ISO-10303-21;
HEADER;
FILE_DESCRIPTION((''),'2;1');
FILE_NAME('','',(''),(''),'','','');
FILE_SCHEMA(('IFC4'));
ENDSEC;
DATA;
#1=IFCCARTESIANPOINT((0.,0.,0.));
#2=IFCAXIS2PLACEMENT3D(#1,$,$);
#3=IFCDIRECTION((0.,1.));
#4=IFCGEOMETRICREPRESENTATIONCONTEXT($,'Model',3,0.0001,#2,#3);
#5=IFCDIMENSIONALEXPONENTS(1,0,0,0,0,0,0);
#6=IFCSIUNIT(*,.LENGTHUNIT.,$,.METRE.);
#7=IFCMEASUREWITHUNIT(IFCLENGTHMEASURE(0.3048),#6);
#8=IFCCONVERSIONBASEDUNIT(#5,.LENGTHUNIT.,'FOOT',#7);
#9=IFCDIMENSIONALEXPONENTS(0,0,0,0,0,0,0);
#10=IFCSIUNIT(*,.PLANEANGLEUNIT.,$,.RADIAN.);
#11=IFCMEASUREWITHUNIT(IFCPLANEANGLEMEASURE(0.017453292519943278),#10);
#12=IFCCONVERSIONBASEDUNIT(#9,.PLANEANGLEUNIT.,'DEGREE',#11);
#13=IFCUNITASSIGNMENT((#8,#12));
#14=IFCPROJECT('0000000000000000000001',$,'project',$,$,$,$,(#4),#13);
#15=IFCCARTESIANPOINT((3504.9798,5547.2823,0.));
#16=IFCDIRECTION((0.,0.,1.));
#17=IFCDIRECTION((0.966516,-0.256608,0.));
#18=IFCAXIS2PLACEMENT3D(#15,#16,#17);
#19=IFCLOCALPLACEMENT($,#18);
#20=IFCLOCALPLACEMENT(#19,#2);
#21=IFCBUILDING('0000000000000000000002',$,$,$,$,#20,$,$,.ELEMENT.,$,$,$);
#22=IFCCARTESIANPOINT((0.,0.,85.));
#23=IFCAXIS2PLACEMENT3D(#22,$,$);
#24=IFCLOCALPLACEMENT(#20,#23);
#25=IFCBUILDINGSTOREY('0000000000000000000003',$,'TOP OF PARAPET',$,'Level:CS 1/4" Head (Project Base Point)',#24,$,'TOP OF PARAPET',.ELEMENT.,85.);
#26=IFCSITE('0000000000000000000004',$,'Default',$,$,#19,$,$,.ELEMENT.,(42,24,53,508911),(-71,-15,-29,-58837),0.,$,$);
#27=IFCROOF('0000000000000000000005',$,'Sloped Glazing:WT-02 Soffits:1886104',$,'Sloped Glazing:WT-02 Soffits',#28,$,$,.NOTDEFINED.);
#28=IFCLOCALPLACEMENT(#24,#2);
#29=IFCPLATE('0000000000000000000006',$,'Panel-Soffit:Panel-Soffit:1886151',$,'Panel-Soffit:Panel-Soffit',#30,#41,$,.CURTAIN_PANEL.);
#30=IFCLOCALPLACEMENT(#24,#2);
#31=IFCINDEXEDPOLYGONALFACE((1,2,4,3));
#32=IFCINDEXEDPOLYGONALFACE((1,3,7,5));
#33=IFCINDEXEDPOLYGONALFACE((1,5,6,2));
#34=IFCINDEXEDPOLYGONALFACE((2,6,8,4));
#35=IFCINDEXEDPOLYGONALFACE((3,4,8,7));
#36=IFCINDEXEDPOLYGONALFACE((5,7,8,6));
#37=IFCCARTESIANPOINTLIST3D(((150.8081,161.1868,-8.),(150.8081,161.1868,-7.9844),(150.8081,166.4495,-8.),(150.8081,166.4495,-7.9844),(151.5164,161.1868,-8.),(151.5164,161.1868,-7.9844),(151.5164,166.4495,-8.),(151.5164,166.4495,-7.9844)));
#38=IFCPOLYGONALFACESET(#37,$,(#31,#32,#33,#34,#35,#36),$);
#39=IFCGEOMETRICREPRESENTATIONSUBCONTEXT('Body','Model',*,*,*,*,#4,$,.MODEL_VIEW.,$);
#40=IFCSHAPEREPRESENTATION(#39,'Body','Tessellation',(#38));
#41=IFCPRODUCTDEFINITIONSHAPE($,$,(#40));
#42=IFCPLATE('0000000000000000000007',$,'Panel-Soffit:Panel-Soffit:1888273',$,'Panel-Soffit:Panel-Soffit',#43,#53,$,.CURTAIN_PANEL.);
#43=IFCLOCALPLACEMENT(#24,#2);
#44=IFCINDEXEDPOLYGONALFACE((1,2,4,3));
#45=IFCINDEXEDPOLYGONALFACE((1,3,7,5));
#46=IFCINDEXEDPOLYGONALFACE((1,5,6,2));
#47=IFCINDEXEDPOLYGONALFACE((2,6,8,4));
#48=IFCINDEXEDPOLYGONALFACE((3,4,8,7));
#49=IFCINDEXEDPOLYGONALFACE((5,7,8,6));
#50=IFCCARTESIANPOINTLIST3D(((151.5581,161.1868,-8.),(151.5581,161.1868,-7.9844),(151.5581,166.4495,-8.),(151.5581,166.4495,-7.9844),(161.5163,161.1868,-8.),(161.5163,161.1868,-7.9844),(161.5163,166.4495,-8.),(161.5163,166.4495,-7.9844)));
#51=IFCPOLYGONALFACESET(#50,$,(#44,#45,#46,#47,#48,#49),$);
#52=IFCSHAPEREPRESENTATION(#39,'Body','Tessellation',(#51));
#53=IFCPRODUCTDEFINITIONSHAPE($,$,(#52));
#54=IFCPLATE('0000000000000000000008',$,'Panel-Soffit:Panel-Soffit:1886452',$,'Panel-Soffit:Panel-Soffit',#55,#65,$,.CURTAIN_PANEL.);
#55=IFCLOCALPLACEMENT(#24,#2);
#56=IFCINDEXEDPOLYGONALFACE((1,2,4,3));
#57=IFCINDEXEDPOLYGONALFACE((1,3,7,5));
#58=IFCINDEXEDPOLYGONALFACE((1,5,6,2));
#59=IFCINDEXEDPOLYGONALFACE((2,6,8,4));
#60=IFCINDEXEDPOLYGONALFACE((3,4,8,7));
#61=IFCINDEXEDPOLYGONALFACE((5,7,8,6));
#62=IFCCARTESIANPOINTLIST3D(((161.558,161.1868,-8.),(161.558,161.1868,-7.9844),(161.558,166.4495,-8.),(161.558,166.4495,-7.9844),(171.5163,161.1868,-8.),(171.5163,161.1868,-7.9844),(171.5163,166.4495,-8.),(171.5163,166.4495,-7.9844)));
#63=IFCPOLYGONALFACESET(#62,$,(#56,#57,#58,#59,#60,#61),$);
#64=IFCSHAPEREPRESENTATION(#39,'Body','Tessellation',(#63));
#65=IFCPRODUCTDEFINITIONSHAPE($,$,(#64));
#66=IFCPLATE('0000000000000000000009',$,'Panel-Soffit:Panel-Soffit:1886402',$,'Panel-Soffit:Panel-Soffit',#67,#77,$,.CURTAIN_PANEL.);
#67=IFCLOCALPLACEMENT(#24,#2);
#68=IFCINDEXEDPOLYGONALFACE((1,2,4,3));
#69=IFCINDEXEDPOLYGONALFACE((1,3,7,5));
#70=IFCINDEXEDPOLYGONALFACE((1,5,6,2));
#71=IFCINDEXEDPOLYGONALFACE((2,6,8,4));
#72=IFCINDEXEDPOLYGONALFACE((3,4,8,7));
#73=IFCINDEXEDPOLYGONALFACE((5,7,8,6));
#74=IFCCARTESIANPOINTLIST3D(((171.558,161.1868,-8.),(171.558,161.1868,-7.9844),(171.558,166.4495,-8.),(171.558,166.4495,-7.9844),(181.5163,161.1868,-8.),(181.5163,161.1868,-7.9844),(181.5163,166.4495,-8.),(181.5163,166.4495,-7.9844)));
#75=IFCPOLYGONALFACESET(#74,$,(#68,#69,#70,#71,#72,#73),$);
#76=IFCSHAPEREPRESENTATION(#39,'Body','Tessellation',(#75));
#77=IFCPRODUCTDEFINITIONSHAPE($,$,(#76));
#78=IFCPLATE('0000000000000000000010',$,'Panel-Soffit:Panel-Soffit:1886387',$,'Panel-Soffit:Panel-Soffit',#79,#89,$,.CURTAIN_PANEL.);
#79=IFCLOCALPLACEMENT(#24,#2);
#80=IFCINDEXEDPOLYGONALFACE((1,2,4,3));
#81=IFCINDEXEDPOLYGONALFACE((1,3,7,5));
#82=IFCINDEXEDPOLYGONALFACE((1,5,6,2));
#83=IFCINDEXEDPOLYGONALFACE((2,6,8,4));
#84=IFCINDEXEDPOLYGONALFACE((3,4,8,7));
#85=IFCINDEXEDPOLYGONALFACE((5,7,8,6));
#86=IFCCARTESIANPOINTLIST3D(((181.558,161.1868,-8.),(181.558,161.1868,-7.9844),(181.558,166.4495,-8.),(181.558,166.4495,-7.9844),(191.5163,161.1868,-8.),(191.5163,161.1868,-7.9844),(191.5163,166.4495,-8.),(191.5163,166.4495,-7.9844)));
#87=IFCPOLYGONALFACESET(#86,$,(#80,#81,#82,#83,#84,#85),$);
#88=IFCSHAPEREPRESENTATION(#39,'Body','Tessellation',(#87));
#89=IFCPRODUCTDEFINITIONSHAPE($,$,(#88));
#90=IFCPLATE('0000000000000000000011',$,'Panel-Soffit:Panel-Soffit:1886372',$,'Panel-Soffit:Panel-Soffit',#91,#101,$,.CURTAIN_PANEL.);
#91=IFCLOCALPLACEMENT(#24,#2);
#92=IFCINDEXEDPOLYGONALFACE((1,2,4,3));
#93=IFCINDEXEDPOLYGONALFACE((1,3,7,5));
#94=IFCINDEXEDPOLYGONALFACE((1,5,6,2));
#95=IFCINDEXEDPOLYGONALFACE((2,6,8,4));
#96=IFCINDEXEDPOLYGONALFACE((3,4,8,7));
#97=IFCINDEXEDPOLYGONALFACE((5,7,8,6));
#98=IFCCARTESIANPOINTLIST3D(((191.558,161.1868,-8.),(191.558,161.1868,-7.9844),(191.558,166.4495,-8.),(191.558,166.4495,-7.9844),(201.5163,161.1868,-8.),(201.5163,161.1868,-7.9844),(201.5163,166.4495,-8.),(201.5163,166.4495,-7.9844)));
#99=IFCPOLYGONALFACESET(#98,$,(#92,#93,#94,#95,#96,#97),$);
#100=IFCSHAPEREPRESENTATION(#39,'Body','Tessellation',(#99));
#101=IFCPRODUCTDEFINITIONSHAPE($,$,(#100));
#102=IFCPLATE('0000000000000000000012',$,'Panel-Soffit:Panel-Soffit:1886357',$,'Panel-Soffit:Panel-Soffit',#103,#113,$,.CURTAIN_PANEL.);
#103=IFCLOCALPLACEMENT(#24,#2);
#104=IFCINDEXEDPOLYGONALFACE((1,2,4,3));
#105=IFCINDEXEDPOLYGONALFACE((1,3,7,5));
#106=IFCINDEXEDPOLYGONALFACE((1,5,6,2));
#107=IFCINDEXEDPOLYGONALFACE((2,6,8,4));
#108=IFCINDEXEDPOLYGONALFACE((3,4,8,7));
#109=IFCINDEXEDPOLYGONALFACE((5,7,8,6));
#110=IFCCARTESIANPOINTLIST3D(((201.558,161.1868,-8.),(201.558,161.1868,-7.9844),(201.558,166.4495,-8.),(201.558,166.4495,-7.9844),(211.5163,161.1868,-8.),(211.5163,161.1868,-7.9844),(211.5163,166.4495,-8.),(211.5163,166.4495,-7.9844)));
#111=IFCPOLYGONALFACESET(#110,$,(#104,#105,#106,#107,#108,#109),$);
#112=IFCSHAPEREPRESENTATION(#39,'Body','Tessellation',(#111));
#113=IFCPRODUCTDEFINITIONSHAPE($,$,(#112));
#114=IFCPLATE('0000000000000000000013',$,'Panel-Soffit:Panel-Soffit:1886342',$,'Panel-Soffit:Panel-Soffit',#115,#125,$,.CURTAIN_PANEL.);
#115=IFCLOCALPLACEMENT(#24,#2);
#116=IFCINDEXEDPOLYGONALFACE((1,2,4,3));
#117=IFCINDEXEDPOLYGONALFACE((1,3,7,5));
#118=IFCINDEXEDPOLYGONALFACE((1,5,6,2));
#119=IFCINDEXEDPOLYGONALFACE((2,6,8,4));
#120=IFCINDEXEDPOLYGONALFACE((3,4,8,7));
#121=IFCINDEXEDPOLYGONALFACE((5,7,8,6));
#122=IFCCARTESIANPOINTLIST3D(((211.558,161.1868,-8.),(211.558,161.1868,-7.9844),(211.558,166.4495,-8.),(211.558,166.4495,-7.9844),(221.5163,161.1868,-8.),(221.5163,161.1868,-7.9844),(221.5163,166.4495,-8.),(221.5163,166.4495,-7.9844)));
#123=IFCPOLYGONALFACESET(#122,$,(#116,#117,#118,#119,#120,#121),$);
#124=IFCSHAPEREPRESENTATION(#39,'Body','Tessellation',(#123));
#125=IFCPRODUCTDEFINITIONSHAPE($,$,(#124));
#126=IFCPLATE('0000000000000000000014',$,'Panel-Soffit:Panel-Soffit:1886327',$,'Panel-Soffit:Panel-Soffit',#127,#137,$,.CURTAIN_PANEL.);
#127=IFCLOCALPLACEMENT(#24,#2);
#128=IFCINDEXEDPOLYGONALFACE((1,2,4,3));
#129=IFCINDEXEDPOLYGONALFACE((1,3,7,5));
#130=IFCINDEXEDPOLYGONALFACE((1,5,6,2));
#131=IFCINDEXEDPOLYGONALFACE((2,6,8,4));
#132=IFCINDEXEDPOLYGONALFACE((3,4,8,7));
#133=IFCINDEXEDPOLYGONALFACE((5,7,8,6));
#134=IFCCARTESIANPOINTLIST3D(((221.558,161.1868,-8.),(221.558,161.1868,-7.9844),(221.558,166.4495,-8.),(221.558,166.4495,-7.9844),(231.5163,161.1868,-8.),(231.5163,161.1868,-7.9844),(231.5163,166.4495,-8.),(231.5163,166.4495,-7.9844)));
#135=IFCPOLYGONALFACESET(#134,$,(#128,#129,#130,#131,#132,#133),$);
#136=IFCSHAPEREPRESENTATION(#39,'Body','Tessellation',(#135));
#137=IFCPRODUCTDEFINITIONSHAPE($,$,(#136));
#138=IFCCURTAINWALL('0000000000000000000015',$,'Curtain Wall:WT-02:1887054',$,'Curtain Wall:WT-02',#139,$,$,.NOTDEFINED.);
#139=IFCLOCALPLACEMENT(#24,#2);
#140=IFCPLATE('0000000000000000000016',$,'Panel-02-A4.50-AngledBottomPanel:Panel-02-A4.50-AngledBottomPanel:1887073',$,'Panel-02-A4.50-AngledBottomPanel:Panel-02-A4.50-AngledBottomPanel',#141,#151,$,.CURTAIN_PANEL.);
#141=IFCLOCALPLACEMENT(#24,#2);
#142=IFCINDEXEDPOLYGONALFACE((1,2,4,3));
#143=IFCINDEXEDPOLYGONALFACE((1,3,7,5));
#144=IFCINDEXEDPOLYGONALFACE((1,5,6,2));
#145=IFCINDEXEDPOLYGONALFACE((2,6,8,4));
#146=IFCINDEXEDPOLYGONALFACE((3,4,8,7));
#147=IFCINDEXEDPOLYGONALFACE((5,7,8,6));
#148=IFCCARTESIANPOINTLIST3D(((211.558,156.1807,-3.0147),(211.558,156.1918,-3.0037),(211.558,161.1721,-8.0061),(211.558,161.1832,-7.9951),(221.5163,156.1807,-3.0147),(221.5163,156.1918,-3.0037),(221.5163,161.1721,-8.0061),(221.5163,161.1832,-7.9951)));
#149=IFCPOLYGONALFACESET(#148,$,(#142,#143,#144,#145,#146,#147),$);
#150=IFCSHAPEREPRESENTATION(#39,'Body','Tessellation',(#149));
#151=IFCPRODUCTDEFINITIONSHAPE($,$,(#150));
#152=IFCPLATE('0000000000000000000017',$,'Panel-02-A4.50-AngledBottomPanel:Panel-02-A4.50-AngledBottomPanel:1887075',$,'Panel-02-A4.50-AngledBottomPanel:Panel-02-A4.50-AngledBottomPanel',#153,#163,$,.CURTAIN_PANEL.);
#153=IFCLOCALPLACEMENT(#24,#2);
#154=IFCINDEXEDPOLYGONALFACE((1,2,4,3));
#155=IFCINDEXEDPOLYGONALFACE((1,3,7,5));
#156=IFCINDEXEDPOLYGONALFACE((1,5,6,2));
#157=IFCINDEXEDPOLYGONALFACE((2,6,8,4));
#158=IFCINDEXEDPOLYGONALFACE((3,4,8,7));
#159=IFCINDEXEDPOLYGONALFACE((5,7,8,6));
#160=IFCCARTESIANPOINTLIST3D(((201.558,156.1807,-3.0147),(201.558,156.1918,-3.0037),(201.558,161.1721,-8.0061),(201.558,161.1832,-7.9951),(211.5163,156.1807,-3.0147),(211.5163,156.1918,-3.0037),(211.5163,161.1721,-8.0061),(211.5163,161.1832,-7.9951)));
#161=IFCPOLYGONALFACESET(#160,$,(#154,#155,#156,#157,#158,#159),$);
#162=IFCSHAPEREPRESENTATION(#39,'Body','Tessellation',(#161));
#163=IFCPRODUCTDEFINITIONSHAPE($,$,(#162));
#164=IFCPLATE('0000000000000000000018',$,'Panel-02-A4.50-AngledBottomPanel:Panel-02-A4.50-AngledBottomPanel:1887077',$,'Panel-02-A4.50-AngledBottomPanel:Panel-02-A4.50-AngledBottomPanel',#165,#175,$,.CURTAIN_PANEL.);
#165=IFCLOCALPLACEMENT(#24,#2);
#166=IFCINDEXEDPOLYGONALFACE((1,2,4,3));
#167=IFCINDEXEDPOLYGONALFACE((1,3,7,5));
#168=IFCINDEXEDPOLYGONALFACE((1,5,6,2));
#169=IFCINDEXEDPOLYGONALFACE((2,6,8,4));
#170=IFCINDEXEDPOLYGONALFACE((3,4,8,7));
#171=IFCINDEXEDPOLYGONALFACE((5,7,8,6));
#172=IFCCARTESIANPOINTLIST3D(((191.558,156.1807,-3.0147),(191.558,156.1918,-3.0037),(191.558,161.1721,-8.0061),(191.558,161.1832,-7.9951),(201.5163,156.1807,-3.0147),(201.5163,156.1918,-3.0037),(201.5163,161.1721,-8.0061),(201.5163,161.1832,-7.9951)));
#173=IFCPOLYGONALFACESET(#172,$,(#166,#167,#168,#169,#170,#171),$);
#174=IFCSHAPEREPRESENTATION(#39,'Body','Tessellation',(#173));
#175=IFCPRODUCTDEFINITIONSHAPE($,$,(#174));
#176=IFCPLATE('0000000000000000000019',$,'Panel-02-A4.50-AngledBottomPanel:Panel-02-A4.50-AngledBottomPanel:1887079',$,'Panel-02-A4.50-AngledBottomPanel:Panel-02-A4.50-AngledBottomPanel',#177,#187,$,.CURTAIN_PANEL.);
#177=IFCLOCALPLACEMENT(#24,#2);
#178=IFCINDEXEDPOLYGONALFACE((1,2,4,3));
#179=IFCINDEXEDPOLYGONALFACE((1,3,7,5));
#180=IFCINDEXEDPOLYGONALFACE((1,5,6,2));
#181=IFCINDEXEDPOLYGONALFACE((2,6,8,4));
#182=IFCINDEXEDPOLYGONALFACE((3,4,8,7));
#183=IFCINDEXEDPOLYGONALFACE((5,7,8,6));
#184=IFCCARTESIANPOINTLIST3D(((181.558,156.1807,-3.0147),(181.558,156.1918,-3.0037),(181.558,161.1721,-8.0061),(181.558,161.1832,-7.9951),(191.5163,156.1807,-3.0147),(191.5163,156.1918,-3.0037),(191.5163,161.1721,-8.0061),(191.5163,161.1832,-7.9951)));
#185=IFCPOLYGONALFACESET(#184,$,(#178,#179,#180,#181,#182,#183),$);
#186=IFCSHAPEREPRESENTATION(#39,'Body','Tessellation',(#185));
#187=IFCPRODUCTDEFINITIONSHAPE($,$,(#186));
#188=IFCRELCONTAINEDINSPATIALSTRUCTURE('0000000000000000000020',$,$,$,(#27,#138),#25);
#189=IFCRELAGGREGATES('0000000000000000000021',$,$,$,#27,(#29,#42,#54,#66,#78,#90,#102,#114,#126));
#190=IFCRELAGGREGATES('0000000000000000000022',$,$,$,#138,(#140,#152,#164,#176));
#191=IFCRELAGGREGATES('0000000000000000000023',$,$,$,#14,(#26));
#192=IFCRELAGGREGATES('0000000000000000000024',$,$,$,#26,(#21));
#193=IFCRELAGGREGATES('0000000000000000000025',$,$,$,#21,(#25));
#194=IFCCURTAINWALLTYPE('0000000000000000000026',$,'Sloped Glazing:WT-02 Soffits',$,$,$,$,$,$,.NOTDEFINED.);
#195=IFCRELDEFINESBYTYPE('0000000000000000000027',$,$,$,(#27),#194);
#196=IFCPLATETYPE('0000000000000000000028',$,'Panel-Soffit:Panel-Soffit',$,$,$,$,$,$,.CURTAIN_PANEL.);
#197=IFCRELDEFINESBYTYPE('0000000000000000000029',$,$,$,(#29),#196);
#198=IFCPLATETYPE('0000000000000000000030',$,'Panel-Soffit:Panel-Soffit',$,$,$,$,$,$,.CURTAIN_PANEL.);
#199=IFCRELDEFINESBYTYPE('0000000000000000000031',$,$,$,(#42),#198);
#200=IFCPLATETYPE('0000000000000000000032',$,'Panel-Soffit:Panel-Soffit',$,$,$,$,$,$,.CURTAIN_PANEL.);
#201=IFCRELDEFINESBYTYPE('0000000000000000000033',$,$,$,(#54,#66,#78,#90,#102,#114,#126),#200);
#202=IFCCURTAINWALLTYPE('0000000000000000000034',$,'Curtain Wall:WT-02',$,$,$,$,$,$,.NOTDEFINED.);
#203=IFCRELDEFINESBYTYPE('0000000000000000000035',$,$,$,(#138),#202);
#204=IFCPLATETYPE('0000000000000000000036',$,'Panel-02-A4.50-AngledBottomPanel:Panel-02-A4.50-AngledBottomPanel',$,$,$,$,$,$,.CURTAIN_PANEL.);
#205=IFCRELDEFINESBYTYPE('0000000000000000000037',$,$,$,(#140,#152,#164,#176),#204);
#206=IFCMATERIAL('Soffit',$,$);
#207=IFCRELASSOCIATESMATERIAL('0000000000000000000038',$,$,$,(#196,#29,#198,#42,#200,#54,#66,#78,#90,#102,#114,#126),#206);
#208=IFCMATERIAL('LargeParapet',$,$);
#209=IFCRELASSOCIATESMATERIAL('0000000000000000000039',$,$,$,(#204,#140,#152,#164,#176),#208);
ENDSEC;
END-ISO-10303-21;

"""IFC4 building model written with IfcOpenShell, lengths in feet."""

from ifc_helpers import new_model, entity, si_unit, converted_unit, direction, frame, origin, place, context, subcontext, project, spatial, indexed_curve, outline, extrude, source, transform, mapped, material, type_object, type_shapes, element, aggregate, save


model = new_model("IFC4")

# Units and contexts
model_context = context("Model", 3, precision=0.0001, world=origin(), true_north=direction((0.0, 1.0)))
body_context = subcontext(model_context, "Body", "Model", "MODEL_VIEW")
ifc_project = project(units=[converted_unit("LENGTHUNIT", "FOOT", entity("IfcLengthMeasure", 0.3048), si_unit("LENGTHUNIT", "METRE"), dimensions=[1, 0, 0, 0, 0, 0, 0]), converted_unit("PLANEANGLEUNIT", "DEGREE", entity("IfcPlaneAngleMeasure", 0.017453292519943278), si_unit("PLANEANGLEUNIT", "RADIAN"), dimensions=[0, 0, 0, 0, 0, 0, 0])], contexts=[model_context])

# Site, building, storey
site_placement = place(None, frame((3504.9798, 5547.2823, 0.0), z_axis=(0.0, 0.0, 1.0), x_axis=(0.966516, -0.256608, 0.0)))
site = spatial("IfcSite", under=ifc_project, at=site_placement, Name="Default", CompositionType="ELEMENT", RefLatitude=(42, 24, 53, 508911), RefLongitude=(-71, -15, -29, -58837), RefElevation=0.0)
building_placement = place(site_placement, origin())
building = spatial("IfcBuilding", under=site, at=building_placement, CompositionType="ELEMENT")
storey_placement = place(building_placement, frame((0.0, 0.0, 85.0)))
storey = spatial("IfcBuildingStorey", under=building, at=storey_placement, Name="TOP OF PARAPET", ObjectType="Level:CS 1/4\" Head (Project Base Point)", LongName="TOP OF PARAPET", CompositionType="ELEMENT", Elevation=85.0)

# Shared definitions
curtain_wall_type_1 = type_object("IfcCurtainWallType", Name="Curtain Wall:WT-02", PredefinedType="NOTDEFINED")
ifc_material_1 = material(Name="LargeParapet")

# Roof, plates
curtain_wall_type_2 = type_object("IfcCurtainWallType", Name="Sloped Glazing:WT-02 Soffits", PredefinedType="NOTDEFINED")
roof_1_placement = place(storey_placement, frame((0.0, 0.0, -85.0)))
roof_1 = element("IfcRoof", 1, at=roof_1_placement, inside=storey, type_object=curtain_wall_type_2, Name="Sloped Glazing:WT-02 Soffits:1886104", ObjectType="Sloped Glazing:WT-02 Soffits", PredefinedType="NOTDEFINED")
ifc_material_2 = material(Name="Soffit")
plate_type_1 = type_object("IfcPlateType", Name="Panel-Soffit:Panel-Soffit", PredefinedType="CURTAIN_PANEL", material=ifc_material_2)
shared_shape_1 = source(origin(), body_context, "Body", "SweptSolid", [
    extrude(outline(indexed_curve([(-0.0078, -0.3542), (0.0078, -0.3542), (0.0078, 0.3542), (-0.0078, 0.3542), (-0.0078, -0.3542)], self_intersect=False)), frame((0.3542, 0.0078, 0.0), z_axis=(0.0, 0.0, 1.0), x_axis=(0.0, -1.0, 0.0)), (0.0, 0.0, 1.0), 5.2626),
])
type_shapes(plate_type_1, [shared_shape_1])
plate_1_placement = place(roof_1_placement, frame((150.8081, 161.1868, 77.0156), z_axis=(0.0, 1.0, 0.0), x_axis=(1.0, 0.0, 0.0)))
plate_1 = element("IfcPlate", 2, at=plate_1_placement, type_object=plate_type_1, material=ifc_material_2, Name="Panel-Soffit:Panel-Soffit:1886151", ObjectType="Panel-Soffit:Panel-Soffit", PredefinedType="CURTAIN_PANEL", context=body_context, shape_type="MappedRepresentation", body=[
    mapped(shared_shape_1, transform((0.0, 0.0, 0.0), scale=1.0)),
])
plate_type_2 = type_object("IfcPlateType", Name="Panel-Soffit:Panel-Soffit", PredefinedType="CURTAIN_PANEL", material=ifc_material_2)
shared_shape_2 = source(origin(), body_context, "Body", "SweptSolid", [
    extrude(outline(indexed_curve([(-0.0078, -4.9791), (0.0078, -4.9791), (0.0078, 4.9791), (-0.0078, 4.9791), (-0.0078, -4.9791)], self_intersect=False)), frame((4.9791, 0.0078, 0.0), z_axis=(0.0, 0.0, 1.0), x_axis=(0.0, -1.0, 0.0)), (0.0, 0.0, 1.0), 5.2626),
])
type_shapes(plate_type_2, [shared_shape_2])
plate_2_placement = place(roof_1_placement, frame((151.5581, 161.1868, 77.0156), z_axis=(0.0, 1.0, 0.0), x_axis=(1.0, 0.0, 0.0)))
plate_2 = element("IfcPlate", 3, at=plate_2_placement, type_object=plate_type_2, material=ifc_material_2, Name="Panel-Soffit:Panel-Soffit:1888273", ObjectType="Panel-Soffit:Panel-Soffit", PredefinedType="CURTAIN_PANEL", context=body_context, shape_type="MappedRepresentation", body=[
    mapped(shared_shape_2, transform((0.0, 0.0, 0.0), scale=1.0)),
])
plate_type_3 = type_object("IfcPlateType", Name="Panel-Soffit:Panel-Soffit", PredefinedType="CURTAIN_PANEL", material=ifc_material_2)
shared_shape_3 = source(origin(), body_context, "Body", "SweptSolid", [
    extrude(outline(indexed_curve([(-0.0078, -4.9792), (0.0078, -4.9792), (0.0078, 4.9792), (-0.0078, 4.9792), (-0.0078, -4.9792)], self_intersect=False)), frame((4.9792, 0.0078, 0.0), z_axis=(0.0, 0.0, 1.0), x_axis=(0.0, -1.0, 0.0)), (0.0, 0.0, 1.0), 5.2626),
])
type_shapes(plate_type_3, [shared_shape_3])
plate_3_placement = place(roof_1_placement, frame((161.558, 161.1868, 77.0156), z_axis=(0.0, 1.0, 0.0), x_axis=(1.0, 0.0, 0.0)))
plate_3 = element("IfcPlate", 4, at=plate_3_placement, type_object=plate_type_3, material=ifc_material_2, Name="Panel-Soffit:Panel-Soffit:1886452", ObjectType="Panel-Soffit:Panel-Soffit", PredefinedType="CURTAIN_PANEL", context=body_context, shape_type="MappedRepresentation", body=[
    mapped(shared_shape_3, transform((0.0, 0.0, 0.0), scale=1.0)),
])
plate_4_placement = place(roof_1_placement, frame((171.558, 161.1868, 77.0156), z_axis=(0.0, 1.0, 0.0), x_axis=(1.0, 0.0, 0.0)))
plate_4 = element("IfcPlate", 5, at=plate_4_placement, type_object=plate_type_3, material=ifc_material_2, Name="Panel-Soffit:Panel-Soffit:1886402", ObjectType="Panel-Soffit:Panel-Soffit", PredefinedType="CURTAIN_PANEL", context=body_context, shape_type="MappedRepresentation", body=[
    mapped(shared_shape_3, transform((0.0, 0.0, 0.0), scale=1.0)),
])
plate_5_placement = place(roof_1_placement, frame((181.558, 161.1868, 77.0156), z_axis=(0.0, 1.0, 0.0), x_axis=(1.0, 0.0, 0.0)))
plate_5 = element("IfcPlate", 6, at=plate_5_placement, type_object=plate_type_3, material=ifc_material_2, Name="Panel-Soffit:Panel-Soffit:1886387", ObjectType="Panel-Soffit:Panel-Soffit", PredefinedType="CURTAIN_PANEL", context=body_context, shape_type="MappedRepresentation", body=[
    mapped(shared_shape_3, transform((0.0, 0.0, 0.0), scale=1.0)),
])
plate_6_placement = place(roof_1_placement, frame((191.558, 161.1868, 77.0156), z_axis=(0.0, 1.0, 0.0), x_axis=(1.0, 0.0, 0.0)))
plate_6 = element("IfcPlate", 7, at=plate_6_placement, type_object=plate_type_3, material=ifc_material_2, Name="Panel-Soffit:Panel-Soffit:1886372", ObjectType="Panel-Soffit:Panel-Soffit", PredefinedType="CURTAIN_PANEL", context=body_context, shape_type="MappedRepresentation", body=[
    mapped(shared_shape_3, transform((0.0, 0.0, 0.0), scale=1.0)),
])
plate_7_placement = place(roof_1_placement, frame((201.558, 161.1868, 77.0156), z_axis=(0.0, 1.0, 0.0), x_axis=(1.0, 0.0, 0.0)))
plate_7 = element("IfcPlate", 8, at=plate_7_placement, type_object=plate_type_3, material=ifc_material_2, Name="Panel-Soffit:Panel-Soffit:1886357", ObjectType="Panel-Soffit:Panel-Soffit", PredefinedType="CURTAIN_PANEL", context=body_context, shape_type="MappedRepresentation", body=[
    mapped(shared_shape_3, transform((0.0, 0.0, 0.0), scale=1.0)),
])
plate_8_placement = place(roof_1_placement, frame((211.558, 161.1868, 77.0156), z_axis=(0.0, 1.0, 0.0), x_axis=(1.0, 0.0, 0.0)))
plate_8 = element("IfcPlate", 9, at=plate_8_placement, type_object=plate_type_3, material=ifc_material_2, Name="Panel-Soffit:Panel-Soffit:1886342", ObjectType="Panel-Soffit:Panel-Soffit", PredefinedType="CURTAIN_PANEL", context=body_context, shape_type="MappedRepresentation", body=[
    mapped(shared_shape_3, transform((0.0, 0.0, 0.0), scale=1.0)),
])
plate_9_placement = place(roof_1_placement, frame((221.558, 161.1868, 77.0156), z_axis=(0.0, 1.0, 0.0), x_axis=(1.0, 0.0, 0.0)))
plate_9 = element("IfcPlate", 10, at=plate_9_placement, type_object=plate_type_3, material=ifc_material_2, Name="Panel-Soffit:Panel-Soffit:1886327", ObjectType="Panel-Soffit:Panel-Soffit", PredefinedType="CURTAIN_PANEL", context=body_context, shape_type="MappedRepresentation", body=[
    mapped(shared_shape_3, transform((0.0, 0.0, 0.0), scale=1.0)),
])
aggregate(roof_1, [plate_1, plate_2, plate_3, plate_4, plate_5, plate_6, plate_7, plate_8, plate_9])

# Curtain wall, plates
curtain_wall_1_placement = place(storey_placement, frame((0.0, 0.0, -85.0)))
curtain_wall_1 = element("IfcCurtainWall", 11, at=curtain_wall_1_placement, inside=storey, type_object=curtain_wall_type_1, Name="Curtain Wall:WT-02:1887054", ObjectType="Curtain Wall:WT-02", PredefinedType="NOTDEFINED")
plate_type_4 = type_object("IfcPlateType", Name="Panel-02-A4.50-AngledBottomPanel:Panel-02-A4.50-AngledBottomPanel", PredefinedType="CURTAIN_PANEL", material=ifc_material_1)
shared_shape_4 = source(origin(), body_context, "Body", "SweptSolid", [
    extrude(outline(indexed_curve([(-0.0078, -4.9792), (0.0078, -4.9792), (0.0078, 4.9792), (-0.0078, 4.9792), (-0.0078, -4.9792)], self_intersect=False)), frame((4.9792, 0.0078, 0.0), z_axis=(0.0, 0.0, 1.0), x_axis=(0.0, -1.0, 0.0)), (0.0, 0.0, 1.0), 7.0589),
])
type_shapes(plate_type_4, [shared_shape_4])
plate_10_placement = place(curtain_wall_1_placement, frame((221.5163, 161.1832, 77.0049), z_axis=(0.0, -0.707107, 0.707107), x_axis=(-1.0, 0.0, 0.0)))
plate_10 = element("IfcPlate", 12, at=plate_10_placement, type_object=plate_type_4, material=ifc_material_1, Name="Panel-02-A4.50-AngledBottomPanel:Panel-02-A4.50-AngledBottomPanel:1887073", ObjectType="Panel-02-A4.50-AngledBottomPanel:Panel-02-A4.50-AngledBottomPanel", PredefinedType="CURTAIN_PANEL", context=body_context, shape_type="MappedRepresentation", body=[
    mapped(shared_shape_4, transform((0.0, 0.0, 0.0), scale=1.0)),
])
plate_11_placement = place(curtain_wall_1_placement, frame((211.5163, 161.1832, 77.0049), z_axis=(0.0, -0.707107, 0.707107), x_axis=(-1.0, 0.0, 0.0)))
plate_11 = element("IfcPlate", 13, at=plate_11_placement, type_object=plate_type_4, material=ifc_material_1, Name="Panel-02-A4.50-AngledBottomPanel:Panel-02-A4.50-AngledBottomPanel:1887075", ObjectType="Panel-02-A4.50-AngledBottomPanel:Panel-02-A4.50-AngledBottomPanel", PredefinedType="CURTAIN_PANEL", context=body_context, shape_type="MappedRepresentation", body=[
    mapped(shared_shape_4, transform((0.0, 0.0, 0.0), scale=1.0)),
])
plate_12_placement = place(curtain_wall_1_placement, frame((201.5163, 161.1832, 77.0049), z_axis=(0.0, -0.707107, 0.707107), x_axis=(-1.0, 0.0, 0.0)))
plate_12 = element("IfcPlate", 14, at=plate_12_placement, type_object=plate_type_4, material=ifc_material_1, Name="Panel-02-A4.50-AngledBottomPanel:Panel-02-A4.50-AngledBottomPanel:1887077", ObjectType="Panel-02-A4.50-AngledBottomPanel:Panel-02-A4.50-AngledBottomPanel", PredefinedType="CURTAIN_PANEL", context=body_context, shape_type="MappedRepresentation", body=[
    mapped(shared_shape_4, transform((0.0, 0.0, 0.0), scale=1.0)),
])
plate_13_placement = place(curtain_wall_1_placement, frame((191.5163, 161.1832, 77.0049), z_axis=(0.0, -0.707107, 0.707107), x_axis=(-1.0, 0.0, 0.0)))
plate_13 = element("IfcPlate", 15, at=plate_13_placement, type_object=plate_type_4, material=ifc_material_1, Name="Panel-02-A4.50-AngledBottomPanel:Panel-02-A4.50-AngledBottomPanel:1887079", ObjectType="Panel-02-A4.50-AngledBottomPanel:Panel-02-A4.50-AngledBottomPanel", PredefinedType="CURTAIN_PANEL", context=body_context, shape_type="MappedRepresentation", body=[
    mapped(shared_shape_4, transform((0.0, 0.0, 0.0), scale=1.0)),
])
aggregate(curtain_wall_1, [plate_10, plate_11, plate_12, plate_13])

save(model, "model.ifc")
